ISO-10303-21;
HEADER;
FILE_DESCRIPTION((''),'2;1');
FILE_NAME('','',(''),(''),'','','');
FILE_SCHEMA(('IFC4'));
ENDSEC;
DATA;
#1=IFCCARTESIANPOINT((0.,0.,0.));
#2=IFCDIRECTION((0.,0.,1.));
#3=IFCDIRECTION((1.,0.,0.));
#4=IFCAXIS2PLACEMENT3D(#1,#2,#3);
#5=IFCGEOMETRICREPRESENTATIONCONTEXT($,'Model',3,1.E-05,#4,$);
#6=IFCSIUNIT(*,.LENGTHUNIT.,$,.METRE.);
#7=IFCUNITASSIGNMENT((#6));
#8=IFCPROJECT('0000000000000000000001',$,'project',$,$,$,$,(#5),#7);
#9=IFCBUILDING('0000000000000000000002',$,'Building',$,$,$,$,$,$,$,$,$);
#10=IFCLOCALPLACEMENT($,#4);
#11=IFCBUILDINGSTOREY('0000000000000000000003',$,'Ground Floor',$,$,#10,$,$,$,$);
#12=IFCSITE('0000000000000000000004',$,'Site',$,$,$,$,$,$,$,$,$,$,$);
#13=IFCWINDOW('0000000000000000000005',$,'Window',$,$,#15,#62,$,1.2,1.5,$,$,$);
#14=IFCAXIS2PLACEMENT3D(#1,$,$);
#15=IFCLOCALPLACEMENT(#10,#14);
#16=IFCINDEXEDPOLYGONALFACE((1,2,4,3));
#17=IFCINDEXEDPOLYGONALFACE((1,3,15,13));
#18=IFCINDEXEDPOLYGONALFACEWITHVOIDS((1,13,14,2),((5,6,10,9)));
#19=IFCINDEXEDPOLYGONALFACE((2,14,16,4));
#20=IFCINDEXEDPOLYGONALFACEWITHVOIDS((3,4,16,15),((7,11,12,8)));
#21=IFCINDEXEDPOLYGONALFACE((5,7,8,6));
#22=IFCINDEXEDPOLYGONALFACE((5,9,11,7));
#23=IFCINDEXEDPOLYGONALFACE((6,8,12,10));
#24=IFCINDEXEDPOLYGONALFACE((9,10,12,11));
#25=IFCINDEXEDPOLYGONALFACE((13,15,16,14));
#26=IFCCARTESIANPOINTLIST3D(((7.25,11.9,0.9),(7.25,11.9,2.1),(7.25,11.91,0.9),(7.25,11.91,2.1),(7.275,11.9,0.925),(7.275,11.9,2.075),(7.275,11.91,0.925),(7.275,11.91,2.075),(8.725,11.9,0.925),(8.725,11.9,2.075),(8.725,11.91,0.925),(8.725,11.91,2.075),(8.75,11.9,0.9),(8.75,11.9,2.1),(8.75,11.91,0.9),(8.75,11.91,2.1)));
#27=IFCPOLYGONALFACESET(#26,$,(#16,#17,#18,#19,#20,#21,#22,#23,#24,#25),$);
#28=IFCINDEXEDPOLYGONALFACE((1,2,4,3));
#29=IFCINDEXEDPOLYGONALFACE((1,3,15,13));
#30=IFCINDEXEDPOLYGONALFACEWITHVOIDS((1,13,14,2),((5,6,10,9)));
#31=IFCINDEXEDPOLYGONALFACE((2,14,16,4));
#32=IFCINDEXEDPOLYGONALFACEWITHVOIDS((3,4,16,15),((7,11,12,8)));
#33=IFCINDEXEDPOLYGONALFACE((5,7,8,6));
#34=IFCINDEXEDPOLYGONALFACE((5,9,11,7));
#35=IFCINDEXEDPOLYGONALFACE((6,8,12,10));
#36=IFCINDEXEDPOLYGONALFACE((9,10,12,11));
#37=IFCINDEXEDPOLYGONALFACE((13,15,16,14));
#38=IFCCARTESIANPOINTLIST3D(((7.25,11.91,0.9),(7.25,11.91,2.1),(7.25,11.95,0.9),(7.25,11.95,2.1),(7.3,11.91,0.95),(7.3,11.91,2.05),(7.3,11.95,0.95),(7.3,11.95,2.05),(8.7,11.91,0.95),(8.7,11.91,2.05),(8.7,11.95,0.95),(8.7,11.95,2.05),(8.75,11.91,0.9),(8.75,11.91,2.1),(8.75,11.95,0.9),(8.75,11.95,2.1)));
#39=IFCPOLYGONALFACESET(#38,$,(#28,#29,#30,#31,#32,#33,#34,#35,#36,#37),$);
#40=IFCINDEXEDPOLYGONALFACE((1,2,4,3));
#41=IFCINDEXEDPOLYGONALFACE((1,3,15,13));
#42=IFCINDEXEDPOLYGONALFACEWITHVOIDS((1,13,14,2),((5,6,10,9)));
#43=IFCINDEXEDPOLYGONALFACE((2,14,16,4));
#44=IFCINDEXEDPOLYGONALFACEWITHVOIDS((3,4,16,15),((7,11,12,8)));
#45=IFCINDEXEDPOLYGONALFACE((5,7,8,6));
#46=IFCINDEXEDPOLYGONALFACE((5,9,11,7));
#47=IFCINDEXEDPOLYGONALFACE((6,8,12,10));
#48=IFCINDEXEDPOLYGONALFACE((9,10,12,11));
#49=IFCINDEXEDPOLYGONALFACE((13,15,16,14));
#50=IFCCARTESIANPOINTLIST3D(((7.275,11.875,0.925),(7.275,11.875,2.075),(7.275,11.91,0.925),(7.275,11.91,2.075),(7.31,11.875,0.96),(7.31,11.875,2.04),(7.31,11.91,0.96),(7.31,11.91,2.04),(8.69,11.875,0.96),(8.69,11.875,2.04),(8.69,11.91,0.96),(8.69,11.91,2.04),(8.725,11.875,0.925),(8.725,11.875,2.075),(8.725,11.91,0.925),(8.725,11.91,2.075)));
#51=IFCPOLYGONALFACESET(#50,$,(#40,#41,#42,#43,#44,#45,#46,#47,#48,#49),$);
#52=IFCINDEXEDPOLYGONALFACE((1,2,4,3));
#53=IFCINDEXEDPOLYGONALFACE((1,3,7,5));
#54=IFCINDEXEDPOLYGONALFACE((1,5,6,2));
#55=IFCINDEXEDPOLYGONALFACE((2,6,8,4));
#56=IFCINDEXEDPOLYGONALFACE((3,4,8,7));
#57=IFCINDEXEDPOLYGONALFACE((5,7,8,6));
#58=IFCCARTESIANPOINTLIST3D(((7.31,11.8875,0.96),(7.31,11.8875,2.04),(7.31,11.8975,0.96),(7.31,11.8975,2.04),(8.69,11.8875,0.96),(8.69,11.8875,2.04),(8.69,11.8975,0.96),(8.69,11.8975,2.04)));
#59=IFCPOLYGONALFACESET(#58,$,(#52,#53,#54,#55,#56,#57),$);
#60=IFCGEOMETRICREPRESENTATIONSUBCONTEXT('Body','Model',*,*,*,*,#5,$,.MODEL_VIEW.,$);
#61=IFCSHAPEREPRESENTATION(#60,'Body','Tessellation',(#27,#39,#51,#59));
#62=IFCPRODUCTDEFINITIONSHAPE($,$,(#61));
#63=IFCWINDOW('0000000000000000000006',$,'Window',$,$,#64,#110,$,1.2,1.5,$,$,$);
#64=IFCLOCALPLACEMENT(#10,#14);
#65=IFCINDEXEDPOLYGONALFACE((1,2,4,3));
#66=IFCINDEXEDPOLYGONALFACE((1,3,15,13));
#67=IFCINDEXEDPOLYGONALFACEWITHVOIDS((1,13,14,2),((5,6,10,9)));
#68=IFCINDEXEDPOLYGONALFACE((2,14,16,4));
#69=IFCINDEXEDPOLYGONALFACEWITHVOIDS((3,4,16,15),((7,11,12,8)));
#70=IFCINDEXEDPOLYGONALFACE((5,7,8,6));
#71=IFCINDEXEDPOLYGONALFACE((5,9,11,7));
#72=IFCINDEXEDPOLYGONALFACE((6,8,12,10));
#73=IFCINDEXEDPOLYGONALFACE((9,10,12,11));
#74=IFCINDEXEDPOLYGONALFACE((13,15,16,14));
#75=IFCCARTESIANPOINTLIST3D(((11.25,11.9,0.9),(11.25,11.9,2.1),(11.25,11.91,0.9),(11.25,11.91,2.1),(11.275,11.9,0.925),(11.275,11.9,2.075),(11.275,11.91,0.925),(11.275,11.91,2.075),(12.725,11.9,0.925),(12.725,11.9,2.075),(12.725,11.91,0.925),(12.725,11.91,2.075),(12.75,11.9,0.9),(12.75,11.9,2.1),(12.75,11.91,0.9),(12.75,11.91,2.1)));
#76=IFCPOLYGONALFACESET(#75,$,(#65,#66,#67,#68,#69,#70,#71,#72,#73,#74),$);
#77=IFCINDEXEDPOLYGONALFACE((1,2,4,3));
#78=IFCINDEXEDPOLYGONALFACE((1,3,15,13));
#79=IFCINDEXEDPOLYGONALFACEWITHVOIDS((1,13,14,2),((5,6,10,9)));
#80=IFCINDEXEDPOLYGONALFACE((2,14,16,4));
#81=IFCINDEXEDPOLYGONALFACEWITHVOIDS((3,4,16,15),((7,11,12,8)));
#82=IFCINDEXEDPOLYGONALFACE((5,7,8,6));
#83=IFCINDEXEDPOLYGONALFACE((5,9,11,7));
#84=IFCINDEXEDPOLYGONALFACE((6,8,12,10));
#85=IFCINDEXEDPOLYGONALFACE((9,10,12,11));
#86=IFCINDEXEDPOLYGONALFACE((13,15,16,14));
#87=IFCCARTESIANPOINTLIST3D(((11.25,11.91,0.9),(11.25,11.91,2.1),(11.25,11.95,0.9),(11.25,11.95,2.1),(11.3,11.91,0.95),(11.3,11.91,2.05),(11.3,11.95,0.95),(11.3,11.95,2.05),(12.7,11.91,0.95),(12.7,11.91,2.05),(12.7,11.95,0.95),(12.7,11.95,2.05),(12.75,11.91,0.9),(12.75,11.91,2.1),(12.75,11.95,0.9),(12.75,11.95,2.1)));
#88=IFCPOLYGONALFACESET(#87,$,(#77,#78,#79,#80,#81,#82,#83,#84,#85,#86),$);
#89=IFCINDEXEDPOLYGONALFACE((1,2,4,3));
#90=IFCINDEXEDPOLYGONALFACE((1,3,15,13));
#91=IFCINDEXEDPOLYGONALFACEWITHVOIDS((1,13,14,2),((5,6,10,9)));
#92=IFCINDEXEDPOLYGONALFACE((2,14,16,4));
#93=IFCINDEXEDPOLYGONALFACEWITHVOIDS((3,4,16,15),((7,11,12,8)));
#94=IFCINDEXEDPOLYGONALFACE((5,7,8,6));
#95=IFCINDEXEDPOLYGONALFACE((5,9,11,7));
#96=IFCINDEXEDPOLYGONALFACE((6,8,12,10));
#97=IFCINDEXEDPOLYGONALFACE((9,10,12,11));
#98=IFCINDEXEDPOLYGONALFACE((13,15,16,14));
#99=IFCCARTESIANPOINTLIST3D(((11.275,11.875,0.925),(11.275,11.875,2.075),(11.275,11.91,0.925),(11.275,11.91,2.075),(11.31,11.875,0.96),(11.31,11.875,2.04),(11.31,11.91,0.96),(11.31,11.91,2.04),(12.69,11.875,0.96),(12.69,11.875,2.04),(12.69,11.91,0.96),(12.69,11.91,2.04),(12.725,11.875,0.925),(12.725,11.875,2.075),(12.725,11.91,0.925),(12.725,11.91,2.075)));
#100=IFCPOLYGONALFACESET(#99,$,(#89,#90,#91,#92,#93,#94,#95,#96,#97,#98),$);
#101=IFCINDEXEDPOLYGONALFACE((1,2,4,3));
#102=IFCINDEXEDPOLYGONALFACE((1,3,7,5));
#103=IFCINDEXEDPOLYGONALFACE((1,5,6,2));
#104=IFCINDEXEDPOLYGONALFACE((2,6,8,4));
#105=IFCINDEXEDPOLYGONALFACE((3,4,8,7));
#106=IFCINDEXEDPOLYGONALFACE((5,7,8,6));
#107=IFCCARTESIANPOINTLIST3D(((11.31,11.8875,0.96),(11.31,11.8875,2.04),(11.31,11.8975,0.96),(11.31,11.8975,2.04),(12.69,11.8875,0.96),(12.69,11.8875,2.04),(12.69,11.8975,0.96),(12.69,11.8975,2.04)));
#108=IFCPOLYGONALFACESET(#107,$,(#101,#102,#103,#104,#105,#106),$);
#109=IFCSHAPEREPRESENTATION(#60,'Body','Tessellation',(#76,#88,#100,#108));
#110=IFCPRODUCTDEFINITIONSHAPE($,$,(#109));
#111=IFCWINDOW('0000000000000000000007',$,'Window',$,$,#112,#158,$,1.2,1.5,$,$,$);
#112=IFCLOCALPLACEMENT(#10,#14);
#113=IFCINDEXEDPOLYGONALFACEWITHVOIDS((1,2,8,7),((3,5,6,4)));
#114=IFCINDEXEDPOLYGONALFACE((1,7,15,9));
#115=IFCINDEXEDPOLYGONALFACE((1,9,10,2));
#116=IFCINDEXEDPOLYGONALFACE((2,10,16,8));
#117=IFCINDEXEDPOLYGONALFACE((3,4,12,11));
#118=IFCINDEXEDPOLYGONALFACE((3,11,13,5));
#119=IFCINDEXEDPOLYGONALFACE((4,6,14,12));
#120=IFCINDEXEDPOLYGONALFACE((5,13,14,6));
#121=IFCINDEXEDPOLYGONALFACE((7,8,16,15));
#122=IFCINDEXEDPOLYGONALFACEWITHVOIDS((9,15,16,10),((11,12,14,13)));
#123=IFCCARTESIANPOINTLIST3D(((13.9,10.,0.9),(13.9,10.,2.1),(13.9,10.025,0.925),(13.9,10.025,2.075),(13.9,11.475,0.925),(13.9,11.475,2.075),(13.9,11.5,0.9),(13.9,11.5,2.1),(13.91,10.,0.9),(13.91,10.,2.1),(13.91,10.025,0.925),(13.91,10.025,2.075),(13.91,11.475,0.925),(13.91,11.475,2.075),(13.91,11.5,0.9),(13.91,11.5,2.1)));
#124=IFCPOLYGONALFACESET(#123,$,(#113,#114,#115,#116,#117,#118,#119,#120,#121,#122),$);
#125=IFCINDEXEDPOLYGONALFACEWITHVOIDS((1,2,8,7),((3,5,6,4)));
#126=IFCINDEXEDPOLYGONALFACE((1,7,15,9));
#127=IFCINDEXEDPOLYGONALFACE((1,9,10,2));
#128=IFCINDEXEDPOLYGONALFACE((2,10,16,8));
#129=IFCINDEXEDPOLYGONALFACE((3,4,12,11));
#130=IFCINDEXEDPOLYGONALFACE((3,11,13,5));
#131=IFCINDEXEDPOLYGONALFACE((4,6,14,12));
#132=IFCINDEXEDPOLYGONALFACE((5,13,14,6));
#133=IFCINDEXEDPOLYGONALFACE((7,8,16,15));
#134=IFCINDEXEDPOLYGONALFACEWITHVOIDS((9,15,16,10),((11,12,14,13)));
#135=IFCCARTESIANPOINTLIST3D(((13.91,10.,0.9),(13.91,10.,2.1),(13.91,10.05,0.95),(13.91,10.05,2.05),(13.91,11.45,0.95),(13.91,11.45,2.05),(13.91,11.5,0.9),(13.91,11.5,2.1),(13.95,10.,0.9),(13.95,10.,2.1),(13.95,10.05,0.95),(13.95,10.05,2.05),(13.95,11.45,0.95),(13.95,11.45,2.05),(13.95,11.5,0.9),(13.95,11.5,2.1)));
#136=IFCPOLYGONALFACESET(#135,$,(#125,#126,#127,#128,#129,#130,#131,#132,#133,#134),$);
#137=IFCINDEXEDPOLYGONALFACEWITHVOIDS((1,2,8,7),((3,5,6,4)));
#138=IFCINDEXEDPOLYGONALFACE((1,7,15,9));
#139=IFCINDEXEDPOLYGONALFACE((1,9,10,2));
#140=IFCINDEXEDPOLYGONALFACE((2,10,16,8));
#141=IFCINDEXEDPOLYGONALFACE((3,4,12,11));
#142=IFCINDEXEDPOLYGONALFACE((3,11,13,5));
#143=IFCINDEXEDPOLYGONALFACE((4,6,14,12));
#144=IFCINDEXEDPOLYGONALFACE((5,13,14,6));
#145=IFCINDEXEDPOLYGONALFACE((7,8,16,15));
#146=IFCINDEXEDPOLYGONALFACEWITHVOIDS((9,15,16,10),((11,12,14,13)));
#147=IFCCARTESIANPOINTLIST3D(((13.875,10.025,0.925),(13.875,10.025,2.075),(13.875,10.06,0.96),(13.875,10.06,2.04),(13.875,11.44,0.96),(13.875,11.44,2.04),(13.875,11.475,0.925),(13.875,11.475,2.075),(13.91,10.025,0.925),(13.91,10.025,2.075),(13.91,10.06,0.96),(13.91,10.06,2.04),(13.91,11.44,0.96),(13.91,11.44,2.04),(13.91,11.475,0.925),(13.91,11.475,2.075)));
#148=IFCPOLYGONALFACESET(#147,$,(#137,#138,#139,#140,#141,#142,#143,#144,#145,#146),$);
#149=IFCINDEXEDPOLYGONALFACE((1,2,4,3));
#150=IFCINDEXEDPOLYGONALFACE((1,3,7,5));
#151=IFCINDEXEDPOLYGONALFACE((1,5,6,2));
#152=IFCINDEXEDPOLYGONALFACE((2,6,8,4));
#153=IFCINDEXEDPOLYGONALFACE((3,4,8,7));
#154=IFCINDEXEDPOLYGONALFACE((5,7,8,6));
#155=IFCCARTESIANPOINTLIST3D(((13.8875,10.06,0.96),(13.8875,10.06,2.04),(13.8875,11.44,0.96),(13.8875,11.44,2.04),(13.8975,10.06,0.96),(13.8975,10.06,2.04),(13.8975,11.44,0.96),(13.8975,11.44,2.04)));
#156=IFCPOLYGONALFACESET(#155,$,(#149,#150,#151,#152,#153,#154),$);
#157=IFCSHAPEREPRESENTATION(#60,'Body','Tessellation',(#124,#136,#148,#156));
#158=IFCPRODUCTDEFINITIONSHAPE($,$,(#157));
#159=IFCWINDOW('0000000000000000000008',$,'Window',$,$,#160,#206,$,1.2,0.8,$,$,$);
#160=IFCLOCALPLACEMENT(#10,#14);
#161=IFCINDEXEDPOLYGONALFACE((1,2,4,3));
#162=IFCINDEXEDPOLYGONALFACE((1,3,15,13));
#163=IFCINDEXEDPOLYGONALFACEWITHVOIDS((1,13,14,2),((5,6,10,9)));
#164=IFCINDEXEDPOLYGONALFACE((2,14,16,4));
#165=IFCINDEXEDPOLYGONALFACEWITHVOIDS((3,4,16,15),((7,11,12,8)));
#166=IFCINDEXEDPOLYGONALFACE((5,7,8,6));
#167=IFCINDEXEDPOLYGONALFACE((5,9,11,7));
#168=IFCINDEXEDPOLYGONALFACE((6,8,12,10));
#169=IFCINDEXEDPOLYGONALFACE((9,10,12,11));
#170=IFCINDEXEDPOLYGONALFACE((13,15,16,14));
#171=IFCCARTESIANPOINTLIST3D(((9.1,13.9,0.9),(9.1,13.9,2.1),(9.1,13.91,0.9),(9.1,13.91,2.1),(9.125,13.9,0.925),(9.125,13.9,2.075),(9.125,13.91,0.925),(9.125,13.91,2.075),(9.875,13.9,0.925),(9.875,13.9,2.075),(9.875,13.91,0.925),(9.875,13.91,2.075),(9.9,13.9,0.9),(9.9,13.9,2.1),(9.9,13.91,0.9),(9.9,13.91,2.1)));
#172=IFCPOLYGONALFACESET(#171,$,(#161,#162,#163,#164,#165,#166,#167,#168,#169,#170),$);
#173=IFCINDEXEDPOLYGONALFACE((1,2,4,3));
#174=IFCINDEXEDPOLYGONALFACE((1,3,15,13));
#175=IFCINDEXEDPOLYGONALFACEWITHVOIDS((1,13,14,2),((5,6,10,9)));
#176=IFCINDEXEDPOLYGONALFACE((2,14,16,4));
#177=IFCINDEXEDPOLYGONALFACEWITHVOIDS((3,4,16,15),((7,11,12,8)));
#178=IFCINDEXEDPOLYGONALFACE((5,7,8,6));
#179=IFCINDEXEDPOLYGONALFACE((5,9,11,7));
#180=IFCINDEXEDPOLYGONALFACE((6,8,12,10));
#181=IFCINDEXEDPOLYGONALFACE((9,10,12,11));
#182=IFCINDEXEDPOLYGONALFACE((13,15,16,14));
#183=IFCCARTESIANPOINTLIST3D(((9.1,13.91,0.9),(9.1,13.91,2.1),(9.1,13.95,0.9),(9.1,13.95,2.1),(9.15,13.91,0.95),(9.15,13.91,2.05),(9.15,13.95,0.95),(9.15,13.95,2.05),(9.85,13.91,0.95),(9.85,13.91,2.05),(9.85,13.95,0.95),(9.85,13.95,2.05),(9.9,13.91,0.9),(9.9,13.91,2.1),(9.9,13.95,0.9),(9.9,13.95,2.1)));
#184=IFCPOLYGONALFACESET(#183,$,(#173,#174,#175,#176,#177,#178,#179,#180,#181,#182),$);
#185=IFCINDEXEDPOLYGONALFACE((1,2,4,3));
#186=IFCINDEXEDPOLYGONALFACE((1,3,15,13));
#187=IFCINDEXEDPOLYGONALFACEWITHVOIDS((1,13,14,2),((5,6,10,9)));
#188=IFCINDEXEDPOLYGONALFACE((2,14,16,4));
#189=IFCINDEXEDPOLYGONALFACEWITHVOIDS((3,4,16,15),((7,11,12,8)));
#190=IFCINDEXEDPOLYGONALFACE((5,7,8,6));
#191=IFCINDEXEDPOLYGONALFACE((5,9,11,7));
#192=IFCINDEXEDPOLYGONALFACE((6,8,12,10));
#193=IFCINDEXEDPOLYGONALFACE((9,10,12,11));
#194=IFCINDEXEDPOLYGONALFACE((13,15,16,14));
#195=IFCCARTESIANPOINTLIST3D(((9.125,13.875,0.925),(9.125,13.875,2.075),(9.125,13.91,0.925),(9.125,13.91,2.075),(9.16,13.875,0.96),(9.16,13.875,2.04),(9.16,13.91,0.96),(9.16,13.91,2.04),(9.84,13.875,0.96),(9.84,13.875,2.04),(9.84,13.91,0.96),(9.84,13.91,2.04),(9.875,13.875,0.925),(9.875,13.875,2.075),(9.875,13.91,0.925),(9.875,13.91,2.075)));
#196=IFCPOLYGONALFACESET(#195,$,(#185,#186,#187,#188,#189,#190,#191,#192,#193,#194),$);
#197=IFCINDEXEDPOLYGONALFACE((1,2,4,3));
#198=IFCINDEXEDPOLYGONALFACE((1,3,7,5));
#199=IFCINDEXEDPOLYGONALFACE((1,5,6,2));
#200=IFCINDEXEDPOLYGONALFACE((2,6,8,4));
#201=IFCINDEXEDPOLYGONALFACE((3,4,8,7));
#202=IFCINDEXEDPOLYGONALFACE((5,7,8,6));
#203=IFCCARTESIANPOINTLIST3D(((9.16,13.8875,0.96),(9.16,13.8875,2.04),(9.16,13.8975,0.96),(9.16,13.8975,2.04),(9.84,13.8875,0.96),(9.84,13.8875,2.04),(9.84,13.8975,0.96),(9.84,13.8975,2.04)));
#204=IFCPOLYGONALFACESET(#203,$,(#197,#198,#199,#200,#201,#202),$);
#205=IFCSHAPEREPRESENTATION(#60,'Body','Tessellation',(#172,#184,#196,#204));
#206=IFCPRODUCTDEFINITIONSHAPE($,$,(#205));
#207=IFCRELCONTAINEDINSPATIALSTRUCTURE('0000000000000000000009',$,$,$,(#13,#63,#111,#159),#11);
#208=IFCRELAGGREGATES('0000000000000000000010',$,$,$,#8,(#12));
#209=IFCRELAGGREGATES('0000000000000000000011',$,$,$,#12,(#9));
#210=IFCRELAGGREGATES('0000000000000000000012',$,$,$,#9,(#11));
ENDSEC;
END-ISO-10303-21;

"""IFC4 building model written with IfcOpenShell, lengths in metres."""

from ifc_helpers import new_model, si_unit, frame, origin_with_axes, place, context, subcontext, project, spatial, line, indexed_curve, outline, extrude, element, save


model = new_model("IFC4")

# Units and contexts
model_context = context("Model", 3, precision=1e-05, world=origin_with_axes())
body_context = subcontext(model_context, "Body", "Model", "MODEL_VIEW")
ifc_project = project(units=[si_unit("LENGTHUNIT", "METRE")], contexts=[model_context])

# Site, building, storey
site = spatial("IfcSite", under=ifc_project, Name="Site")
building = spatial("IfcBuilding", under=site, Name="Building")
storey_placement = place(None, origin_with_axes())
storey = spatial("IfcBuildingStorey", under=building, at=storey_placement, Name="Ground Floor")

# Windows
for number, where, z_axis, x_axis, name in (
    (1, (8.75, 12.0, 0.9), (0.0, 0.0, 1.0), (-1.0, 0.0, 0.0), "Window"),
    (2, (12.75, 12.0, 0.9), (0.0, 0.0, 1.0), (-1.0, 0.0, 0.0), "Window"),
    (3, (14.0, 10.0, 0.9), (0.0, 0.0, 1.0), (0.0, 1.0, 0.0), "Window"),
):
    element("IfcWindow", number, at=place(storey_placement, frame(where, z_axis=z_axis, x_axis=x_axis)), inside=storey, Name=name, OverallHeight=1.2, OverallWidth=1.5, context=body_context, shape_type="SweptSolid", body=[
        extrude(outline(indexed_curve([(0.0, 0.0), (1.5, 0.0), (1.5, 1.2), (0.0, 1.2)], segments=[line(1, 2, 3, 4, 1)]), holes=[indexed_curve([(0.025, 0.025), (1.475, 0.025), (1.475, 1.175), (0.025, 1.175)], segments=[line(1, 2, 3, 4, 1)])]), frame((0.0, 0.09, 0.0), z_axis=(0.0, -1.0, 0.0), x_axis=(1.0, 0.0, 0.0)), (0.0, 0.0, -1.0), 0.01),
        extrude(outline(indexed_curve([(0.0, 0.0), (1.5, 0.0), (1.5, 1.2), (0.0, 1.2)], segments=[line(1, 2, 3, 4, 1)]), holes=[indexed_curve([(0.05, 0.05), (1.45, 0.05), (1.45, 1.15), (0.05, 1.15)], segments=[line(1, 2, 3, 4, 1)])]), frame((0.0, 0.05, 0.0), z_axis=(0.0, -1.0, 0.0), x_axis=(1.0, 0.0, 0.0)), (0.0, 0.0, -1.0), 0.04),
        extrude(outline(indexed_curve([(0.0, 0.0), (1.45, 0.0), (1.45, 1.15), (0.0, 1.15)], segments=[line(1, 2, 3, 4, 1)]), holes=[indexed_curve([(0.035, 0.035), (1.415, 0.035), (1.415, 1.115), (0.035, 1.115)], segments=[line(1, 2, 3, 4, 1)])]), frame((0.025, 0.09, 0.025), z_axis=(0.0, -1.0, 0.0), x_axis=(1.0, 0.0, 0.0)), (0.0, 0.0, -1.0), 0.035),
        extrude(outline(indexed_curve([(0.035, 0.035), (1.415, 0.035), (1.415, 1.115), (0.035, 1.115)], segments=[line(1, 2, 3, 4, 1)])), frame((0.025, 0.1025, 0.025), z_axis=(0.0, -1.0, 0.0), x_axis=(1.0, 0.0, 0.0)), (0.0, 0.0, -1.0), 0.01),
    ])
for number, where, z_axis, x_axis, name in (
    (4, (9.9, 14.0, 0.9), (0.0, 0.0, 1.0), (-1.0, 0.0, 0.0), "Window"),
):
    element("IfcWindow", number, at=place(storey_placement, frame(where, z_axis=z_axis, x_axis=x_axis)), inside=storey, Name=name, OverallHeight=1.2, OverallWidth=0.8, context=body_context, shape_type="SweptSolid", body=[
        extrude(outline(indexed_curve([(0.0, 0.0), (0.8, 0.0), (0.8, 1.2), (0.0, 1.2)], segments=[line(1, 2, 3, 4, 1)]), holes=[indexed_curve([(0.025, 0.025), (0.775, 0.025), (0.775, 1.175), (0.025, 1.175)], segments=[line(1, 2, 3, 4, 1)])]), frame((0.0, 0.09, 0.0), z_axis=(0.0, -1.0, 0.0), x_axis=(1.0, 0.0, 0.0)), (0.0, 0.0, -1.0), 0.01),
        extrude(outline(indexed_curve([(0.0, 0.0), (0.8, 0.0), (0.8, 1.2), (0.0, 1.2)], segments=[line(1, 2, 3, 4, 1)]), holes=[indexed_curve([(0.05, 0.05), (0.75, 0.05), (0.75, 1.15), (0.05, 1.15)], segments=[line(1, 2, 3, 4, 1)])]), frame((0.0, 0.05, 0.0), z_axis=(0.0, -1.0, 0.0), x_axis=(1.0, 0.0, 0.0)), (0.0, 0.0, -1.0), 0.04),
        extrude(outline(indexed_curve([(0.0, 0.0), (0.75, 0.0), (0.75, 1.15), (0.0, 1.15)], segments=[line(1, 2, 3, 4, 1)]), holes=[indexed_curve([(0.035, 0.035), (0.715, 0.035), (0.715, 1.115), (0.035, 1.115)], segments=[line(1, 2, 3, 4, 1)])]), frame((0.025, 0.09, 0.025), z_axis=(0.0, -1.0, 0.0), x_axis=(1.0, 0.0, 0.0)), (0.0, 0.0, -1.0), 0.035),
        extrude(outline(indexed_curve([(0.035, 0.035), (0.715, 0.035), (0.715, 1.115), (0.035, 1.115)], segments=[line(1, 2, 3, 4, 1)])), frame((0.025, 0.1025, 0.025), z_axis=(0.0, -1.0, 0.0), x_axis=(1.0, 0.0, 0.0)), (0.0, 0.0, -1.0), 0.01),
    ])

save(model, "model.ifc")
